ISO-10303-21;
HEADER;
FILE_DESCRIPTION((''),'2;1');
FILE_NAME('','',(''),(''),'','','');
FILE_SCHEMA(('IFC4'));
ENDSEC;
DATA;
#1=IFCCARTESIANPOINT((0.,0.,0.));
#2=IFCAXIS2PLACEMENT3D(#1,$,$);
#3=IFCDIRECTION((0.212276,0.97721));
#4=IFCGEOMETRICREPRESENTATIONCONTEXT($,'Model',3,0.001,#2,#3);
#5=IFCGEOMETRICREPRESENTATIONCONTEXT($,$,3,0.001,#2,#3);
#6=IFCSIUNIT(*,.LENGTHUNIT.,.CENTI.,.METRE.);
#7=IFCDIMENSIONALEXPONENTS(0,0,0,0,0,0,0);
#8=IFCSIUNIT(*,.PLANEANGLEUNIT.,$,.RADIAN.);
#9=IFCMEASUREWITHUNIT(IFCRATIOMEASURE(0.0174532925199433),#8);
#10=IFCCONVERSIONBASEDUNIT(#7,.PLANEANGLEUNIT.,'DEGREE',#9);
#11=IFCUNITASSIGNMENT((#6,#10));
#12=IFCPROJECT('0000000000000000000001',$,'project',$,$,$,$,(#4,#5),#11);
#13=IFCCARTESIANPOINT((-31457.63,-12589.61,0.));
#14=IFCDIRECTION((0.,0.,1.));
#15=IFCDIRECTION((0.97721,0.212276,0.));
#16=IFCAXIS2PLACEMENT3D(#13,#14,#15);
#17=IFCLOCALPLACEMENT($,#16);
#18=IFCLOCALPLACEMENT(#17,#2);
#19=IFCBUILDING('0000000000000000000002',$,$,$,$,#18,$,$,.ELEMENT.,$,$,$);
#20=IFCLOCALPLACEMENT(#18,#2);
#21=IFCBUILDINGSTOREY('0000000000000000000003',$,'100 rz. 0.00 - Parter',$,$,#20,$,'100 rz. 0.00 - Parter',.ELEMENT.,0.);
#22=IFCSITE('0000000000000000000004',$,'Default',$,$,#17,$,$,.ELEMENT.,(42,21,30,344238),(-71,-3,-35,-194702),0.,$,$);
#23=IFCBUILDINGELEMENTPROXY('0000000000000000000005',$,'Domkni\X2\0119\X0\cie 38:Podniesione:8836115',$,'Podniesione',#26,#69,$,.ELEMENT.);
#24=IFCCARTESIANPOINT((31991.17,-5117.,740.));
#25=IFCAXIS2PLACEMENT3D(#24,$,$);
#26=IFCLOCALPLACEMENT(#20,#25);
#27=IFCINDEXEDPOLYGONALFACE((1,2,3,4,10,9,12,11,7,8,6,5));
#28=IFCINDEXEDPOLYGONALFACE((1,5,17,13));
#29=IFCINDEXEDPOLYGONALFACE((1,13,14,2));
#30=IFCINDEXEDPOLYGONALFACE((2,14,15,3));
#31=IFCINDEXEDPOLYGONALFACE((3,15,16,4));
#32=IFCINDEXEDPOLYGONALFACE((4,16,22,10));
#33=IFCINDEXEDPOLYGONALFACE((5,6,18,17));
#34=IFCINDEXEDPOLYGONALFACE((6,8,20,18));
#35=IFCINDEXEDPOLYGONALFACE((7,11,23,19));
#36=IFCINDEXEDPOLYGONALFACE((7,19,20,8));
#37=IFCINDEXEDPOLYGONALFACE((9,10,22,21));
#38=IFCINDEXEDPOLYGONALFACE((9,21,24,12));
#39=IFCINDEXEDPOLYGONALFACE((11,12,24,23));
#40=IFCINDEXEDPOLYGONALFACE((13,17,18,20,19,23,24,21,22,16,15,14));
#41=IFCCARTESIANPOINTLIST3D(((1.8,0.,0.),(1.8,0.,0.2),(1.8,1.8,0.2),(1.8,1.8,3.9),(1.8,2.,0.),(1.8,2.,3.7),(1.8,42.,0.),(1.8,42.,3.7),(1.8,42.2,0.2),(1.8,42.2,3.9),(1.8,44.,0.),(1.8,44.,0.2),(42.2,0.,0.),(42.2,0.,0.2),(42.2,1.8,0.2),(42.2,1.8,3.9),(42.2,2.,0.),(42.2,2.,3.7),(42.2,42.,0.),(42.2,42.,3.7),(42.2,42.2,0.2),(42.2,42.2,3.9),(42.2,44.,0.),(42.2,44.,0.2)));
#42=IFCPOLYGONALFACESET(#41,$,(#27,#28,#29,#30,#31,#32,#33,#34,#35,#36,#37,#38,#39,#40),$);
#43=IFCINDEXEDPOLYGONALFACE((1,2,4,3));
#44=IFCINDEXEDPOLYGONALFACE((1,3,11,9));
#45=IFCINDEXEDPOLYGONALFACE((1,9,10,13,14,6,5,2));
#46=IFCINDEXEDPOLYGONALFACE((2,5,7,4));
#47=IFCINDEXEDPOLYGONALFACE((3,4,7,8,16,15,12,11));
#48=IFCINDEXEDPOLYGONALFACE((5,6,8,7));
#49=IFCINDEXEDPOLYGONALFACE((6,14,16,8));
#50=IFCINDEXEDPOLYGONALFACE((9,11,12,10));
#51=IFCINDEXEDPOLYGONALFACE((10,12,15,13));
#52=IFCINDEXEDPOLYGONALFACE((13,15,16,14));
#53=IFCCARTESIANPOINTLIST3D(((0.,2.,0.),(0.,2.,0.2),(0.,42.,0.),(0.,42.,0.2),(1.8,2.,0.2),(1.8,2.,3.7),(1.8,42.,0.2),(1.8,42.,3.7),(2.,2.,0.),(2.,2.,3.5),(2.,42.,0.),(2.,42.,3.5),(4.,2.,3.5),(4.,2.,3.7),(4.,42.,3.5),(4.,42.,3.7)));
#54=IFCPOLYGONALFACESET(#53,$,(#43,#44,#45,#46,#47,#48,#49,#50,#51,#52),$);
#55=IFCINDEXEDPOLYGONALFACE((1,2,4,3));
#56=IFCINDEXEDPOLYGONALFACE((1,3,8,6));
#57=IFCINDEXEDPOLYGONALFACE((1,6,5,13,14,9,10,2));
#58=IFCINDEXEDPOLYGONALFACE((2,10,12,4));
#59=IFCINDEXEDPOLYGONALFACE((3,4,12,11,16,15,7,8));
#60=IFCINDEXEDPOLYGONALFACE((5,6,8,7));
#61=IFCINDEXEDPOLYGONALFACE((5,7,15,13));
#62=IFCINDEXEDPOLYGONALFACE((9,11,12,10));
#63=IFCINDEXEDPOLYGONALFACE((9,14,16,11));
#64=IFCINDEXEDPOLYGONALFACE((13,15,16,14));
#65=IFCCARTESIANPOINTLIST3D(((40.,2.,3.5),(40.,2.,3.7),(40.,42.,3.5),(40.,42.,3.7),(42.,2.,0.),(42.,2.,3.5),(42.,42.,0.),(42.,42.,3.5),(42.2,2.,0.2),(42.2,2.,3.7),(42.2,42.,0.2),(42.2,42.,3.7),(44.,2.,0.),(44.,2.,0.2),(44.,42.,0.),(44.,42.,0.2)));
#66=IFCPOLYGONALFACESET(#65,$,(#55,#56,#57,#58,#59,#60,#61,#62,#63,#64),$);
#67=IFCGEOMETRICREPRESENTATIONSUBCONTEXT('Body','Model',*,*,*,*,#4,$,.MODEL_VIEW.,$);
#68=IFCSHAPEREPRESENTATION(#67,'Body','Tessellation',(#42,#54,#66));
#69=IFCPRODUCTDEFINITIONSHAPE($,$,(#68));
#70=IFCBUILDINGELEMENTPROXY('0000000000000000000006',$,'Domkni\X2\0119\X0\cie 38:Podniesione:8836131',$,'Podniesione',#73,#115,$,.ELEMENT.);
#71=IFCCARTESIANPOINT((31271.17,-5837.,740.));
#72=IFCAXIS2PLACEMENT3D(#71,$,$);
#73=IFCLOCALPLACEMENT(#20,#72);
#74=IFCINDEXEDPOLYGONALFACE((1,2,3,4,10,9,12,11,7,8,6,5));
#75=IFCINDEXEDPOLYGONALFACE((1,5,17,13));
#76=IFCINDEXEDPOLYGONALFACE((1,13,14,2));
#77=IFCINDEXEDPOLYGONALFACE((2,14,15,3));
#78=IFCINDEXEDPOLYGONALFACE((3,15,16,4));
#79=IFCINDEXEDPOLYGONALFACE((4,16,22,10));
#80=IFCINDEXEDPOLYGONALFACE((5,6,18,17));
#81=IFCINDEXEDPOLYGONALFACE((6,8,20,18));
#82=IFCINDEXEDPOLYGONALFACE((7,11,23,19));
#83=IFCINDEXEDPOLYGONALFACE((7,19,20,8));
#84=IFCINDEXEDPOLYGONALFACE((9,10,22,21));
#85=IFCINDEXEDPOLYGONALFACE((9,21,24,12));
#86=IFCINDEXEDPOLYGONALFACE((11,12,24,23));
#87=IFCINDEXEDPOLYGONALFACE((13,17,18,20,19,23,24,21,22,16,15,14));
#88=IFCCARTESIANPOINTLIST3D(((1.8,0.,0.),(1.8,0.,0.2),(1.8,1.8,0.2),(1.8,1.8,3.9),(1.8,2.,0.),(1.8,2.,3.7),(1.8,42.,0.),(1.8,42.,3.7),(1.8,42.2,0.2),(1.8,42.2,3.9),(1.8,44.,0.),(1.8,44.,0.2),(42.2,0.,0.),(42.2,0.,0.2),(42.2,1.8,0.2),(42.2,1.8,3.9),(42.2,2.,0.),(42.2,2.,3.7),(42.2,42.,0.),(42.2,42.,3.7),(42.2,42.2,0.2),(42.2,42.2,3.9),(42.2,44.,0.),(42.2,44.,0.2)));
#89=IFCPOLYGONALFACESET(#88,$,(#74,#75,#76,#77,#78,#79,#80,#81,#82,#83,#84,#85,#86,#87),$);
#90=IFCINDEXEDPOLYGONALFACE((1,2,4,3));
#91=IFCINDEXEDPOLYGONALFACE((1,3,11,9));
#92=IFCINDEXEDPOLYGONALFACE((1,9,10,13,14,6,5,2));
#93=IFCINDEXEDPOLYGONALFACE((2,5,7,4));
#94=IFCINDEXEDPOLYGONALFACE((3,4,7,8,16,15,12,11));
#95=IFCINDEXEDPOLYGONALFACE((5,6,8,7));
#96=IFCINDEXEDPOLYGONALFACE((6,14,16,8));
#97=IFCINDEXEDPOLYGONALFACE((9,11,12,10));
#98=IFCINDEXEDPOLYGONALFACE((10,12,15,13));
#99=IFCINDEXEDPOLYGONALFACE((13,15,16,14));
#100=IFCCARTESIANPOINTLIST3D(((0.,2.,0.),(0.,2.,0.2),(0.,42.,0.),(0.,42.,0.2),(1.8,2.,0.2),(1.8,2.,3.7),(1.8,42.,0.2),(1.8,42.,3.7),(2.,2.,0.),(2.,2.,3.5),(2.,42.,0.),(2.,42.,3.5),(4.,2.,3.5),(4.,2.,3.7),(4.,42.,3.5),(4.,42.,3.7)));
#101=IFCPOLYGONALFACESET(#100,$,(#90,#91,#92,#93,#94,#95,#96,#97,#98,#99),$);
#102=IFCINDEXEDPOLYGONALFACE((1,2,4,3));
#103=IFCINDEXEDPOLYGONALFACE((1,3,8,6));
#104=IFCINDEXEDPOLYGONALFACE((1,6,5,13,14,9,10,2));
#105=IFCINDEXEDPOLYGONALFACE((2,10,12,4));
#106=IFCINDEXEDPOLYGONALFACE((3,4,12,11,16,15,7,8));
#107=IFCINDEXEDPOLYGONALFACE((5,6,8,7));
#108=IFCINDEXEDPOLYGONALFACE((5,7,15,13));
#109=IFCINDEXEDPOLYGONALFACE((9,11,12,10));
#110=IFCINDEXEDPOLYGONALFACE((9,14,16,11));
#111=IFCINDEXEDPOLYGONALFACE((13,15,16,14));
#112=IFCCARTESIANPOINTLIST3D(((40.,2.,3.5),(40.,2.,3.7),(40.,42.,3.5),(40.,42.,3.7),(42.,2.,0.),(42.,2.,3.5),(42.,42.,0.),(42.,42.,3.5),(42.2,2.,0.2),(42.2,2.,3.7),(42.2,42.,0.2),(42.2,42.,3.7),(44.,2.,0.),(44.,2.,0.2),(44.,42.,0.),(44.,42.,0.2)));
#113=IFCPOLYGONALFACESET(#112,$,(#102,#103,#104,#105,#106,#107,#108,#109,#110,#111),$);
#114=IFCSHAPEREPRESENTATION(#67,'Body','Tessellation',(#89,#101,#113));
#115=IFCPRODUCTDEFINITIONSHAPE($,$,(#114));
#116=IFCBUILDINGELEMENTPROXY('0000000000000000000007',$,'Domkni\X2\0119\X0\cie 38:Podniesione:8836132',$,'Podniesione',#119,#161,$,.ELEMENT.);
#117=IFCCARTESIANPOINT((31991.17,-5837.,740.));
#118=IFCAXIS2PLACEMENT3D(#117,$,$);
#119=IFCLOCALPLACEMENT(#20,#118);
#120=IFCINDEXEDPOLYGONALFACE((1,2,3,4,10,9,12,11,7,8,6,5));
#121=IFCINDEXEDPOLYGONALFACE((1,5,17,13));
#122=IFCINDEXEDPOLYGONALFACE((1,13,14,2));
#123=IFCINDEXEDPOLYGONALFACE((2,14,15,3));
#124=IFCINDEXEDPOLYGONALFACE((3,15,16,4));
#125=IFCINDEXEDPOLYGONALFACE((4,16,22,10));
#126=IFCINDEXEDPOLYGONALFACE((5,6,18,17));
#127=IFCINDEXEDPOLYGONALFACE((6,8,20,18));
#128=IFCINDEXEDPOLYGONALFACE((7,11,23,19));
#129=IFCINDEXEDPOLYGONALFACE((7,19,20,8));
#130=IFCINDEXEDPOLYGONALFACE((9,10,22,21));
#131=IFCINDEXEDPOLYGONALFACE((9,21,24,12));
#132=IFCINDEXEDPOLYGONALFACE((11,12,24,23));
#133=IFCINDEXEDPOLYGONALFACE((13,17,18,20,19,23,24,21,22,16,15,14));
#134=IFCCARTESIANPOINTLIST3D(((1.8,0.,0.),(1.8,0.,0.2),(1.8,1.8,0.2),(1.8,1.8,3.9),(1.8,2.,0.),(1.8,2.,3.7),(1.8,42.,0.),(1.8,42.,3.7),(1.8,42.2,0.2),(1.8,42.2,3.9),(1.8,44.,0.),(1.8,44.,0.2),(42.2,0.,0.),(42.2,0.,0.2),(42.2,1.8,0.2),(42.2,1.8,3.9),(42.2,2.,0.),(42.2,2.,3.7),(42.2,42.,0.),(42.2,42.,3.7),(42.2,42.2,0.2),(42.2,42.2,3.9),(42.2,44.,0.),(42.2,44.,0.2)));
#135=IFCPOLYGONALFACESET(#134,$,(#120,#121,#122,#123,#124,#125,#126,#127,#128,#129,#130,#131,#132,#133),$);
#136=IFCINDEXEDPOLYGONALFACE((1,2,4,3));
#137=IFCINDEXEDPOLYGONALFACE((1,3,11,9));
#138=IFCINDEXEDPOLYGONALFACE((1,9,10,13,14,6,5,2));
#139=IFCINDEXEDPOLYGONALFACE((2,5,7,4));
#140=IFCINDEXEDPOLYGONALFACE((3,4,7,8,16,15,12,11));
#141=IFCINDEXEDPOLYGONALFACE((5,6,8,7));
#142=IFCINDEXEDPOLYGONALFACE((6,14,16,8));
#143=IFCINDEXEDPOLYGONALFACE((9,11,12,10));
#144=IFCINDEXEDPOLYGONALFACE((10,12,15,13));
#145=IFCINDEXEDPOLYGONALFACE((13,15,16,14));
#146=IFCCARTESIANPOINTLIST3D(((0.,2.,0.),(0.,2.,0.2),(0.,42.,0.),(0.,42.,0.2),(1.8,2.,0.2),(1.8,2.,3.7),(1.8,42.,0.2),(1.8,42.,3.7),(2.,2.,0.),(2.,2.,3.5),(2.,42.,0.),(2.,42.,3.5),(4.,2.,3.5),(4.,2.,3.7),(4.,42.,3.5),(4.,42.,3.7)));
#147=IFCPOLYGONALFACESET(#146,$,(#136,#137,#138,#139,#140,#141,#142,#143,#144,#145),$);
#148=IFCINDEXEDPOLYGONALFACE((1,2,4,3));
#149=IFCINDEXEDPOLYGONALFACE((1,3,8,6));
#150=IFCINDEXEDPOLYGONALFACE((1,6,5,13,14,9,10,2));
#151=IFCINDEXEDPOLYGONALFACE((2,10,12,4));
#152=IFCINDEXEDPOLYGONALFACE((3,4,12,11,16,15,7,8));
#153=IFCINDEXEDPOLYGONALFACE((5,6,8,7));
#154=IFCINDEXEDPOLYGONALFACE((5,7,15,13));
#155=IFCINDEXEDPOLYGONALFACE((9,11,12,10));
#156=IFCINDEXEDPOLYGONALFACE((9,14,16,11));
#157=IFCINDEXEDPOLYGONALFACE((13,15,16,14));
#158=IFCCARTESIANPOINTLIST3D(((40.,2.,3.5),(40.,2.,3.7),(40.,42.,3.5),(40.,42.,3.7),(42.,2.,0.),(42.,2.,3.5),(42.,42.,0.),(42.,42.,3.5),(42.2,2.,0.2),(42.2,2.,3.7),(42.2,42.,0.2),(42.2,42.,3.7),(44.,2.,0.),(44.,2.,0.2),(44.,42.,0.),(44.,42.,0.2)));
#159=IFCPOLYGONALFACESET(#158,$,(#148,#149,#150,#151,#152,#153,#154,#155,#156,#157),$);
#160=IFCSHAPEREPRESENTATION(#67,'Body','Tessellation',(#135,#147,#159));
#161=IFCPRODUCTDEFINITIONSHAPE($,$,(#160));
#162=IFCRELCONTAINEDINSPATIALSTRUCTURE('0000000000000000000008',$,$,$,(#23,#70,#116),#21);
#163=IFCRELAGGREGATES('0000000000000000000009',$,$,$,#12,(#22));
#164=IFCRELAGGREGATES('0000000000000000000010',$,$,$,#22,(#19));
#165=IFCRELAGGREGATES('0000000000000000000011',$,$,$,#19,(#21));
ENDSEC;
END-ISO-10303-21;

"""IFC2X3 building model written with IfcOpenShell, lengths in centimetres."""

from ifc_helpers import new_model, entity, si_unit, converted_unit, direction, frame, origin, place, context, subcontext, project, spatial, polyline, outline, extrude, source, transform, mapped, element, save


model = new_model("IFC2X3")

# Units and contexts
model_context = context("Model", 3, precision=0.001, world=origin(), true_north=direction((0.212276, 0.97721)))
context_of_model = context(None, 3, precision=0.001, world=origin(), true_north=direction((0.212276, 0.97721)))
body_context = subcontext(model_context, "Body", "Model", "MODEL_VIEW")
ifc_project = project(units=[si_unit("LENGTHUNIT", "METRE", prefix="CENTI"), converted_unit("PLANEANGLEUNIT", "DEGREE", entity("IfcRatioMeasure", 0.0174532925199433), si_unit("PLANEANGLEUNIT", "RADIAN"), dimensions=[0, 0, 0, 0, 0, 0, 0])], contexts=[model_context, context_of_model])

# Site, building, storey
site_placement = place(None, frame((-31457.63, -12589.61, 0.0), z_axis=(0.0, 0.0, 1.0), x_axis=(0.97721, 0.212276, 0.0)))
site = spatial("IfcSite", under=ifc_project, at=site_placement, Name="Default", CompositionType="ELEMENT", RefLatitude=(42, 21, 30, 344238), RefLongitude=(-71, -3, -35, -194702), RefElevation=0.0)
building_placement = place(site_placement, origin())
building = spatial("IfcBuilding", under=site, at=building_placement, CompositionType="ELEMENT")
storey_placement = place(building_placement, origin())
storey = spatial("IfcBuildingStorey", under=building, at=storey_placement, Name="100 rz. 0.00 - Parter", LongName="100 rz. 0.00 - Parter", CompositionType="ELEMENT", Elevation=0.0)

# Building element proxies
shared_shape_1 = source(origin(), body_context, "Body", "SweptSolid", [
    extrude(outline(polyline([(-2.37, 20.0), (1.33, 20.0), (1.33, 22.0), (1.13, 22.0), (1.13, 20.2), (-2.57, 20.2), (-2.57, -20.2), (1.13, -20.2), (1.13, -22.0), (1.33, -22.0), (1.33, -20.0), (-2.37, -20.0), (-2.37, 20.0)])), frame((1.8, 22.0, 1.33), z_axis=(1.0, 0.0, 0.0), x_axis=(0.0, 0.0, -1.0)), (0.0, 0.0, 1.0), 40.4),
    extrude(outline(polyline([(-1.65, -0.05), (1.85, -0.05), (1.85, 1.95), (1.65, 1.95), (1.65, 0.15), (-1.85, 0.15), (-1.85, -2.05), (-1.65, -2.05), (-1.65, -0.05)])), frame((1.95, 2.0, 1.85), z_axis=(0.0, 1.0, 0.0), x_axis=(0.0, 0.0, -1.0)), (0.0, 0.0, 1.0), 40.0),
    extrude(outline(polyline([(0.05, 1.65), (2.05, 1.65), (2.05, 1.85), (-0.15, 1.85), (-0.15, -1.65), (-1.95, -1.65), (-1.95, -1.85), (0.05, -1.85), (0.05, 1.65)])), frame((42.05, 2.0, 1.85), z_axis=(0.0, 1.0, 0.0), x_axis=(-1.0, 0.0, 0.0)), (0.0, 0.0, 1.0), 40.0),
])
for number, where, name in (
    (1, (31991.17, -5117.0, 740.0), "Domknięcie 38:Podniesione:8836115"),
    (2, (31271.17, -5837.0, 740.0), "Domknięcie 38:Podniesione:8836131"),
    (3, (31991.17, -5837.0, 740.0), "Domknięcie 38:Podniesione:8836132"),
):
    element("IfcBuildingElementProxy", number, at=place(storey_placement, frame(where)), inside=storey, Name=name, ObjectType="Podniesione", CompositionType="ELEMENT", context=body_context, shape_type="MappedRepresentation", body=[
        mapped(shared_shape_1, transform((0.0, 0.0, 0.0), scale=1.0)),
    ])

save(model, "model.ifc")
